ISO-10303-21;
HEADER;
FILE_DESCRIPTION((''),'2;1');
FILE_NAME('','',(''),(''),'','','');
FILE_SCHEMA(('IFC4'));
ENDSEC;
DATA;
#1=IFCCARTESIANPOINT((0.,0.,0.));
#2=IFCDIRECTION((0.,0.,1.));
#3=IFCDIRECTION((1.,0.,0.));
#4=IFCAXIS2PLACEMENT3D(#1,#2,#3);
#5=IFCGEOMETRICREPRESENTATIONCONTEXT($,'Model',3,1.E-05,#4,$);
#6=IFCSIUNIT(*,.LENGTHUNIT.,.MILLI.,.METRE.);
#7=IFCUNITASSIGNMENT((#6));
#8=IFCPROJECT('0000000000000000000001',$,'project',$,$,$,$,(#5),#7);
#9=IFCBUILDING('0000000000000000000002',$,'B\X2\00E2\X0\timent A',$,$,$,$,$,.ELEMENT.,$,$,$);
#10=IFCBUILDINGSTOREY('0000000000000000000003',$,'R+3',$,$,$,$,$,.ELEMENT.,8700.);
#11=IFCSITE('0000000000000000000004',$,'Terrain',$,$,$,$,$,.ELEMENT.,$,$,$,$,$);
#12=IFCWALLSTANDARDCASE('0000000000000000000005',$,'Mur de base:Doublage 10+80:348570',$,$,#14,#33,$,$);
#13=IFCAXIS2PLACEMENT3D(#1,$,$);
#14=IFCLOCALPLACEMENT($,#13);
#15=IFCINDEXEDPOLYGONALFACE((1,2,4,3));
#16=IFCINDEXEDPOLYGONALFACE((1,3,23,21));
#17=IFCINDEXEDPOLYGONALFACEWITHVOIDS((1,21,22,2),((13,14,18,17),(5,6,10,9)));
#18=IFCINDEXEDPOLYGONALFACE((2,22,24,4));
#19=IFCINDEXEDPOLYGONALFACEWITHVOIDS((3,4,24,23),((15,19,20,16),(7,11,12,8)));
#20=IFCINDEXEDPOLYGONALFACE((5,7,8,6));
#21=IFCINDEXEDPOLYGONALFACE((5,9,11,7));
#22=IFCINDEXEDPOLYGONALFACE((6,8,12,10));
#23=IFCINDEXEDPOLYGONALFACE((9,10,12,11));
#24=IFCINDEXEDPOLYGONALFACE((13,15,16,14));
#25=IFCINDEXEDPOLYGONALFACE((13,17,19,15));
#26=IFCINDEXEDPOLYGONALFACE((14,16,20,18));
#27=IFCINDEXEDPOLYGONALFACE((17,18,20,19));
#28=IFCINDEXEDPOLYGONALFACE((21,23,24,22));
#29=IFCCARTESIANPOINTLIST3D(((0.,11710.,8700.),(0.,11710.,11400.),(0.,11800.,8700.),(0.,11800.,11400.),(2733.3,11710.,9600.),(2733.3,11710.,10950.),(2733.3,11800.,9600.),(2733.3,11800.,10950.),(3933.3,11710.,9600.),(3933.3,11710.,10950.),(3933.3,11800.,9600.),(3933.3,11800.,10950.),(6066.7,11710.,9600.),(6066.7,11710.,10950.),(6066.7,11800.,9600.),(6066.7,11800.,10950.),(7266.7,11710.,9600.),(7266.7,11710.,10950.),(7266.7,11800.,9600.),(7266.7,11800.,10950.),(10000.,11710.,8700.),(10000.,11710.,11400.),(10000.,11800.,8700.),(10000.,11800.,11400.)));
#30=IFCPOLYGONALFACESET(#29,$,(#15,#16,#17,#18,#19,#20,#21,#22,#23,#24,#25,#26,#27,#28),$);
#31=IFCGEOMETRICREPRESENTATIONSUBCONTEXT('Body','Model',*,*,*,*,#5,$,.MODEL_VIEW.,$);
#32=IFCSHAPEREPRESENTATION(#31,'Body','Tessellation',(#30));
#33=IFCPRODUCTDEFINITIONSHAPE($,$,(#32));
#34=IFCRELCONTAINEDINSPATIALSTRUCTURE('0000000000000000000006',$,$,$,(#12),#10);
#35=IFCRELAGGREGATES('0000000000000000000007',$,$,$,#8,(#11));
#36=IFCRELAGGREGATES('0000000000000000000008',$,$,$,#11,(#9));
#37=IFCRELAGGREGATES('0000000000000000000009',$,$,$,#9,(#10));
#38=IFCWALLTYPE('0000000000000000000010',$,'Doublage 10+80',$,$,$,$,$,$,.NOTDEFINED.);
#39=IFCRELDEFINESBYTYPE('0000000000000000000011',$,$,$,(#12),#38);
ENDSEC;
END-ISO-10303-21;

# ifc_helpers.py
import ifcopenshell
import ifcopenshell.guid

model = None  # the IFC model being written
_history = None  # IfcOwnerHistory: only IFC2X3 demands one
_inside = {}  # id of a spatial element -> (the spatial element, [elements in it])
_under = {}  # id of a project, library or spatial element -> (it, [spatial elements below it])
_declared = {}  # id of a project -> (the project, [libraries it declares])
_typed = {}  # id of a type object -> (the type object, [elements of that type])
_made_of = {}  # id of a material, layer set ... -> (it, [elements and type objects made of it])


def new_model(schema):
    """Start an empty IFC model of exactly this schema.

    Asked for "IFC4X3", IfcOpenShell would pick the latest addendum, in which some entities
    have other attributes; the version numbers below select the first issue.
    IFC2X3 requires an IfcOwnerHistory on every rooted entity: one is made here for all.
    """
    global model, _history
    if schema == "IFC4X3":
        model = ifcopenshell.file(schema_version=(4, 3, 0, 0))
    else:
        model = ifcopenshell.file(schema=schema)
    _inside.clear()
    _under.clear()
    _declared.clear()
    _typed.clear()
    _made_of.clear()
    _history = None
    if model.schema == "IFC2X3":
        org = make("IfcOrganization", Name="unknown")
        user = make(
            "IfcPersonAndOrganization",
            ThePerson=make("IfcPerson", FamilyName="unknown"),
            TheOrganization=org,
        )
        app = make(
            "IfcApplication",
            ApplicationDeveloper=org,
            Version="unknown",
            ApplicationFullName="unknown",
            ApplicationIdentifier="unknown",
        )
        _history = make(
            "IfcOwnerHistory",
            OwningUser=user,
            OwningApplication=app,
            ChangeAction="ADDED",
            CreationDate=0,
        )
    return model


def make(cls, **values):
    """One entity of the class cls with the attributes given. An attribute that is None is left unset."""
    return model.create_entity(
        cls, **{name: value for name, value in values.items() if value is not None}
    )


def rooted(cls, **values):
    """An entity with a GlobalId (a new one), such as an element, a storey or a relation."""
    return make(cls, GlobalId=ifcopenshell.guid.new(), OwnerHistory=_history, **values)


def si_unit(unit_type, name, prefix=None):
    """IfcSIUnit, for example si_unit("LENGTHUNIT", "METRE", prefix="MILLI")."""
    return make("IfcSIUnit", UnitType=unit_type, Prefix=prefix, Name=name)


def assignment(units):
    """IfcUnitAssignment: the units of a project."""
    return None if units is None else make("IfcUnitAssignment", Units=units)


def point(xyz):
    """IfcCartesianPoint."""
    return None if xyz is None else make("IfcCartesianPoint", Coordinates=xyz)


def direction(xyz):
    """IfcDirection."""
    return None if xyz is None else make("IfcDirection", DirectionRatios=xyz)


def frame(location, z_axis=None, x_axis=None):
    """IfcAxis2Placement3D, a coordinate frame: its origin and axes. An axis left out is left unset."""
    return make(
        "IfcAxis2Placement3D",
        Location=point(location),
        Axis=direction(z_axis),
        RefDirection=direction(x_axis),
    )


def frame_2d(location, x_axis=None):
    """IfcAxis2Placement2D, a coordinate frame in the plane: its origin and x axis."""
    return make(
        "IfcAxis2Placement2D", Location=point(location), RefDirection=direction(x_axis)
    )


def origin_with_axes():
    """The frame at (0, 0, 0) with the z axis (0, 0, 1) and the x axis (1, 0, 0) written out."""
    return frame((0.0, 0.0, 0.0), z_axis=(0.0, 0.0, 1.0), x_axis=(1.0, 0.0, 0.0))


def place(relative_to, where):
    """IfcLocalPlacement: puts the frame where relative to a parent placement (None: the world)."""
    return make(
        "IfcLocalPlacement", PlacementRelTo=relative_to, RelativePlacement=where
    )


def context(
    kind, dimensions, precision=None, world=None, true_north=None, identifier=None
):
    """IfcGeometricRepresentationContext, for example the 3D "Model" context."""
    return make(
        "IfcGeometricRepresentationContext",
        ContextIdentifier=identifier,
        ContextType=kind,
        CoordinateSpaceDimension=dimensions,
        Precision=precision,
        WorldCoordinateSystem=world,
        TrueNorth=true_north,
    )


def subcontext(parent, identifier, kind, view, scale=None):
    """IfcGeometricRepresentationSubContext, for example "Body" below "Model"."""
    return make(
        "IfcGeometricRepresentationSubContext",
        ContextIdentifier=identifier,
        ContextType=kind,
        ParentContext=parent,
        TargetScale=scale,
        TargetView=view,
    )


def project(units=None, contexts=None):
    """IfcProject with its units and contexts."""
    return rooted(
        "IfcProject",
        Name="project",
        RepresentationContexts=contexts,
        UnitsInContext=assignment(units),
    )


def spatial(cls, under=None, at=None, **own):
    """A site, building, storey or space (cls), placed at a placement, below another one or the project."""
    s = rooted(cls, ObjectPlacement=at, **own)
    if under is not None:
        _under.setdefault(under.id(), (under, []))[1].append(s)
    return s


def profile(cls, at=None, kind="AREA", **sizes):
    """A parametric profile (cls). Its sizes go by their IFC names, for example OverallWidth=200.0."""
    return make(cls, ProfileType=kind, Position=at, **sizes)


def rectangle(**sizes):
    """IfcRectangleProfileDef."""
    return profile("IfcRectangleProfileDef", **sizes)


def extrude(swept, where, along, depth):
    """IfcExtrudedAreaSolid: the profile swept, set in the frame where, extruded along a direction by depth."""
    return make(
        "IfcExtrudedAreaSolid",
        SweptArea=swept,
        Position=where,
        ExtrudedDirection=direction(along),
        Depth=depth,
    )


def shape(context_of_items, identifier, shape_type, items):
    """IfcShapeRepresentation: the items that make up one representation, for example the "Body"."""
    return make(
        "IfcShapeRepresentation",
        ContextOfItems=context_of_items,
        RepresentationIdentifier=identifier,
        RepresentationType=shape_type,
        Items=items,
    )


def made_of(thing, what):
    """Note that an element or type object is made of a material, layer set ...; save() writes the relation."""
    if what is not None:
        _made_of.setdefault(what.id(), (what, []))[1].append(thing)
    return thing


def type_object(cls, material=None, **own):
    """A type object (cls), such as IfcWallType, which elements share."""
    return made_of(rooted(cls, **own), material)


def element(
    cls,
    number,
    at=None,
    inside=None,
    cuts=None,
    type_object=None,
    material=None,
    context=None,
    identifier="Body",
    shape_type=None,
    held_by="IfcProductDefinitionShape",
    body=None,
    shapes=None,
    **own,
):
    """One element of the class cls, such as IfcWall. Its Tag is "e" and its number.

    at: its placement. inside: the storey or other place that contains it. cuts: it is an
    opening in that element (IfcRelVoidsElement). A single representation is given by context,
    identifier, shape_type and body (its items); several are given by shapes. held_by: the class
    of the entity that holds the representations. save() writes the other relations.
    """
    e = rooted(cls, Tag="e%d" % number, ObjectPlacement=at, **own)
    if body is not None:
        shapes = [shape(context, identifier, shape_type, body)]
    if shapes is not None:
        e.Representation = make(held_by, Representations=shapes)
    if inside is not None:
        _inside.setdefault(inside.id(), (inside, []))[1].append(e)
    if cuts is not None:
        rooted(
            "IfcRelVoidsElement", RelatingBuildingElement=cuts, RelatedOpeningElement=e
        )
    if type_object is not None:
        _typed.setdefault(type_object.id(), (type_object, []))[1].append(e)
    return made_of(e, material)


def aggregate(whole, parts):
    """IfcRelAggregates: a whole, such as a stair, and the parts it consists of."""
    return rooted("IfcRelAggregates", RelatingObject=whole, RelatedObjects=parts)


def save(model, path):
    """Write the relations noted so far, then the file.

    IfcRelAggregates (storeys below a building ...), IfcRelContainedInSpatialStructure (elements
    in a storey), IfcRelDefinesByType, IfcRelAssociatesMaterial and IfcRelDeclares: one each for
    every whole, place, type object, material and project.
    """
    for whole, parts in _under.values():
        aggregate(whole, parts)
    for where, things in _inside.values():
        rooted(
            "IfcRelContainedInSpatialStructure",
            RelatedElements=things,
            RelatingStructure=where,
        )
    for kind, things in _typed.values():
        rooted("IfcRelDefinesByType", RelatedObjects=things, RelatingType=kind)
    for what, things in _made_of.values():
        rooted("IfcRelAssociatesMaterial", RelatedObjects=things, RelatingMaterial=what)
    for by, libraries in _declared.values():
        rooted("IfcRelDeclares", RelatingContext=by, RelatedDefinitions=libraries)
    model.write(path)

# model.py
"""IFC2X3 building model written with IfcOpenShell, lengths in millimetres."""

from ifc_helpers import new_model, si_unit, frame, frame_2d, origin_with_axes, place, context, subcontext, project, spatial, rectangle, extrude, type_object, element, save


model = new_model("IFC2X3")

# Units and contexts
model_context = context("Model", 3, precision=1e-05, world=origin_with_axes())
body_context = subcontext(model_context, "Body", "Model", "MODEL_VIEW")
ifc_project = project(units=[si_unit("LENGTHUNIT", "METRE", prefix="MILLI")], contexts=[model_context])

# Site, building, storey
site = spatial("IfcSite", under=ifc_project, Name="Terrain", CompositionType="ELEMENT")
building = spatial("IfcBuilding", under=site, Name="Bâtiment A", CompositionType="ELEMENT")
storey = spatial("IfcBuildingStorey", under=building, Name="R+3", CompositionType="ELEMENT", Elevation=8700.0)

# Wall, openings
wall_type_1 = type_object("IfcWallType", Name="Doublage 10+80", PredefinedType="NOTDEFINED")
wall_1_placement = place(None, origin_with_axes())
wall_1 = element("IfcWallStandardCase", 1, at=wall_1_placement, inside=storey, type_object=wall_type_1, Name="Mur de base:Doublage 10+80:348570", context=body_context, shape_type="SweptSolid", body=[
    extrude(rectangle(XDim=10000.0, YDim=90.0, at=frame_2d((5000.0, 11755.0))), frame((0.0, 0.0, 8700.0), z_axis=(0.0, 0.0, 1.0), x_axis=(1.0, 0.0, 0.0)), (0.0, 0.0, 1.0), 2700.0),
])
opening_1_placement = place(None, origin_with_axes())
element("IfcOpeningElement", 2, at=opening_1_placement, cuts=wall_1, context=body_context, shape_type="SweptSolid", body=[
    extrude(rectangle(XDim=1200.0, YDim=210.0, at=frame_2d((3333.3, 11755.0))), frame((0.0, 0.0, 9600.0), z_axis=(0.0, 0.0, 1.0), x_axis=(1.0, 0.0, 0.0)), (0.0, 0.0, 1.0), 1350.0),
])
opening_2_placement = place(None, origin_with_axes())
element("IfcOpeningElement", 3, at=opening_2_placement, cuts=wall_1, context=body_context, shape_type="SweptSolid", body=[
    extrude(rectangle(XDim=1200.0, YDim=210.0, at=frame_2d((6666.7, 11755.0))), frame((0.0, 0.0, 9600.0), z_axis=(0.0, 0.0, 1.0), x_axis=(1.0, 0.0, 0.0)), (0.0, 0.0, 1.0), 1350.0),
])

save(model, "model.ifc")
